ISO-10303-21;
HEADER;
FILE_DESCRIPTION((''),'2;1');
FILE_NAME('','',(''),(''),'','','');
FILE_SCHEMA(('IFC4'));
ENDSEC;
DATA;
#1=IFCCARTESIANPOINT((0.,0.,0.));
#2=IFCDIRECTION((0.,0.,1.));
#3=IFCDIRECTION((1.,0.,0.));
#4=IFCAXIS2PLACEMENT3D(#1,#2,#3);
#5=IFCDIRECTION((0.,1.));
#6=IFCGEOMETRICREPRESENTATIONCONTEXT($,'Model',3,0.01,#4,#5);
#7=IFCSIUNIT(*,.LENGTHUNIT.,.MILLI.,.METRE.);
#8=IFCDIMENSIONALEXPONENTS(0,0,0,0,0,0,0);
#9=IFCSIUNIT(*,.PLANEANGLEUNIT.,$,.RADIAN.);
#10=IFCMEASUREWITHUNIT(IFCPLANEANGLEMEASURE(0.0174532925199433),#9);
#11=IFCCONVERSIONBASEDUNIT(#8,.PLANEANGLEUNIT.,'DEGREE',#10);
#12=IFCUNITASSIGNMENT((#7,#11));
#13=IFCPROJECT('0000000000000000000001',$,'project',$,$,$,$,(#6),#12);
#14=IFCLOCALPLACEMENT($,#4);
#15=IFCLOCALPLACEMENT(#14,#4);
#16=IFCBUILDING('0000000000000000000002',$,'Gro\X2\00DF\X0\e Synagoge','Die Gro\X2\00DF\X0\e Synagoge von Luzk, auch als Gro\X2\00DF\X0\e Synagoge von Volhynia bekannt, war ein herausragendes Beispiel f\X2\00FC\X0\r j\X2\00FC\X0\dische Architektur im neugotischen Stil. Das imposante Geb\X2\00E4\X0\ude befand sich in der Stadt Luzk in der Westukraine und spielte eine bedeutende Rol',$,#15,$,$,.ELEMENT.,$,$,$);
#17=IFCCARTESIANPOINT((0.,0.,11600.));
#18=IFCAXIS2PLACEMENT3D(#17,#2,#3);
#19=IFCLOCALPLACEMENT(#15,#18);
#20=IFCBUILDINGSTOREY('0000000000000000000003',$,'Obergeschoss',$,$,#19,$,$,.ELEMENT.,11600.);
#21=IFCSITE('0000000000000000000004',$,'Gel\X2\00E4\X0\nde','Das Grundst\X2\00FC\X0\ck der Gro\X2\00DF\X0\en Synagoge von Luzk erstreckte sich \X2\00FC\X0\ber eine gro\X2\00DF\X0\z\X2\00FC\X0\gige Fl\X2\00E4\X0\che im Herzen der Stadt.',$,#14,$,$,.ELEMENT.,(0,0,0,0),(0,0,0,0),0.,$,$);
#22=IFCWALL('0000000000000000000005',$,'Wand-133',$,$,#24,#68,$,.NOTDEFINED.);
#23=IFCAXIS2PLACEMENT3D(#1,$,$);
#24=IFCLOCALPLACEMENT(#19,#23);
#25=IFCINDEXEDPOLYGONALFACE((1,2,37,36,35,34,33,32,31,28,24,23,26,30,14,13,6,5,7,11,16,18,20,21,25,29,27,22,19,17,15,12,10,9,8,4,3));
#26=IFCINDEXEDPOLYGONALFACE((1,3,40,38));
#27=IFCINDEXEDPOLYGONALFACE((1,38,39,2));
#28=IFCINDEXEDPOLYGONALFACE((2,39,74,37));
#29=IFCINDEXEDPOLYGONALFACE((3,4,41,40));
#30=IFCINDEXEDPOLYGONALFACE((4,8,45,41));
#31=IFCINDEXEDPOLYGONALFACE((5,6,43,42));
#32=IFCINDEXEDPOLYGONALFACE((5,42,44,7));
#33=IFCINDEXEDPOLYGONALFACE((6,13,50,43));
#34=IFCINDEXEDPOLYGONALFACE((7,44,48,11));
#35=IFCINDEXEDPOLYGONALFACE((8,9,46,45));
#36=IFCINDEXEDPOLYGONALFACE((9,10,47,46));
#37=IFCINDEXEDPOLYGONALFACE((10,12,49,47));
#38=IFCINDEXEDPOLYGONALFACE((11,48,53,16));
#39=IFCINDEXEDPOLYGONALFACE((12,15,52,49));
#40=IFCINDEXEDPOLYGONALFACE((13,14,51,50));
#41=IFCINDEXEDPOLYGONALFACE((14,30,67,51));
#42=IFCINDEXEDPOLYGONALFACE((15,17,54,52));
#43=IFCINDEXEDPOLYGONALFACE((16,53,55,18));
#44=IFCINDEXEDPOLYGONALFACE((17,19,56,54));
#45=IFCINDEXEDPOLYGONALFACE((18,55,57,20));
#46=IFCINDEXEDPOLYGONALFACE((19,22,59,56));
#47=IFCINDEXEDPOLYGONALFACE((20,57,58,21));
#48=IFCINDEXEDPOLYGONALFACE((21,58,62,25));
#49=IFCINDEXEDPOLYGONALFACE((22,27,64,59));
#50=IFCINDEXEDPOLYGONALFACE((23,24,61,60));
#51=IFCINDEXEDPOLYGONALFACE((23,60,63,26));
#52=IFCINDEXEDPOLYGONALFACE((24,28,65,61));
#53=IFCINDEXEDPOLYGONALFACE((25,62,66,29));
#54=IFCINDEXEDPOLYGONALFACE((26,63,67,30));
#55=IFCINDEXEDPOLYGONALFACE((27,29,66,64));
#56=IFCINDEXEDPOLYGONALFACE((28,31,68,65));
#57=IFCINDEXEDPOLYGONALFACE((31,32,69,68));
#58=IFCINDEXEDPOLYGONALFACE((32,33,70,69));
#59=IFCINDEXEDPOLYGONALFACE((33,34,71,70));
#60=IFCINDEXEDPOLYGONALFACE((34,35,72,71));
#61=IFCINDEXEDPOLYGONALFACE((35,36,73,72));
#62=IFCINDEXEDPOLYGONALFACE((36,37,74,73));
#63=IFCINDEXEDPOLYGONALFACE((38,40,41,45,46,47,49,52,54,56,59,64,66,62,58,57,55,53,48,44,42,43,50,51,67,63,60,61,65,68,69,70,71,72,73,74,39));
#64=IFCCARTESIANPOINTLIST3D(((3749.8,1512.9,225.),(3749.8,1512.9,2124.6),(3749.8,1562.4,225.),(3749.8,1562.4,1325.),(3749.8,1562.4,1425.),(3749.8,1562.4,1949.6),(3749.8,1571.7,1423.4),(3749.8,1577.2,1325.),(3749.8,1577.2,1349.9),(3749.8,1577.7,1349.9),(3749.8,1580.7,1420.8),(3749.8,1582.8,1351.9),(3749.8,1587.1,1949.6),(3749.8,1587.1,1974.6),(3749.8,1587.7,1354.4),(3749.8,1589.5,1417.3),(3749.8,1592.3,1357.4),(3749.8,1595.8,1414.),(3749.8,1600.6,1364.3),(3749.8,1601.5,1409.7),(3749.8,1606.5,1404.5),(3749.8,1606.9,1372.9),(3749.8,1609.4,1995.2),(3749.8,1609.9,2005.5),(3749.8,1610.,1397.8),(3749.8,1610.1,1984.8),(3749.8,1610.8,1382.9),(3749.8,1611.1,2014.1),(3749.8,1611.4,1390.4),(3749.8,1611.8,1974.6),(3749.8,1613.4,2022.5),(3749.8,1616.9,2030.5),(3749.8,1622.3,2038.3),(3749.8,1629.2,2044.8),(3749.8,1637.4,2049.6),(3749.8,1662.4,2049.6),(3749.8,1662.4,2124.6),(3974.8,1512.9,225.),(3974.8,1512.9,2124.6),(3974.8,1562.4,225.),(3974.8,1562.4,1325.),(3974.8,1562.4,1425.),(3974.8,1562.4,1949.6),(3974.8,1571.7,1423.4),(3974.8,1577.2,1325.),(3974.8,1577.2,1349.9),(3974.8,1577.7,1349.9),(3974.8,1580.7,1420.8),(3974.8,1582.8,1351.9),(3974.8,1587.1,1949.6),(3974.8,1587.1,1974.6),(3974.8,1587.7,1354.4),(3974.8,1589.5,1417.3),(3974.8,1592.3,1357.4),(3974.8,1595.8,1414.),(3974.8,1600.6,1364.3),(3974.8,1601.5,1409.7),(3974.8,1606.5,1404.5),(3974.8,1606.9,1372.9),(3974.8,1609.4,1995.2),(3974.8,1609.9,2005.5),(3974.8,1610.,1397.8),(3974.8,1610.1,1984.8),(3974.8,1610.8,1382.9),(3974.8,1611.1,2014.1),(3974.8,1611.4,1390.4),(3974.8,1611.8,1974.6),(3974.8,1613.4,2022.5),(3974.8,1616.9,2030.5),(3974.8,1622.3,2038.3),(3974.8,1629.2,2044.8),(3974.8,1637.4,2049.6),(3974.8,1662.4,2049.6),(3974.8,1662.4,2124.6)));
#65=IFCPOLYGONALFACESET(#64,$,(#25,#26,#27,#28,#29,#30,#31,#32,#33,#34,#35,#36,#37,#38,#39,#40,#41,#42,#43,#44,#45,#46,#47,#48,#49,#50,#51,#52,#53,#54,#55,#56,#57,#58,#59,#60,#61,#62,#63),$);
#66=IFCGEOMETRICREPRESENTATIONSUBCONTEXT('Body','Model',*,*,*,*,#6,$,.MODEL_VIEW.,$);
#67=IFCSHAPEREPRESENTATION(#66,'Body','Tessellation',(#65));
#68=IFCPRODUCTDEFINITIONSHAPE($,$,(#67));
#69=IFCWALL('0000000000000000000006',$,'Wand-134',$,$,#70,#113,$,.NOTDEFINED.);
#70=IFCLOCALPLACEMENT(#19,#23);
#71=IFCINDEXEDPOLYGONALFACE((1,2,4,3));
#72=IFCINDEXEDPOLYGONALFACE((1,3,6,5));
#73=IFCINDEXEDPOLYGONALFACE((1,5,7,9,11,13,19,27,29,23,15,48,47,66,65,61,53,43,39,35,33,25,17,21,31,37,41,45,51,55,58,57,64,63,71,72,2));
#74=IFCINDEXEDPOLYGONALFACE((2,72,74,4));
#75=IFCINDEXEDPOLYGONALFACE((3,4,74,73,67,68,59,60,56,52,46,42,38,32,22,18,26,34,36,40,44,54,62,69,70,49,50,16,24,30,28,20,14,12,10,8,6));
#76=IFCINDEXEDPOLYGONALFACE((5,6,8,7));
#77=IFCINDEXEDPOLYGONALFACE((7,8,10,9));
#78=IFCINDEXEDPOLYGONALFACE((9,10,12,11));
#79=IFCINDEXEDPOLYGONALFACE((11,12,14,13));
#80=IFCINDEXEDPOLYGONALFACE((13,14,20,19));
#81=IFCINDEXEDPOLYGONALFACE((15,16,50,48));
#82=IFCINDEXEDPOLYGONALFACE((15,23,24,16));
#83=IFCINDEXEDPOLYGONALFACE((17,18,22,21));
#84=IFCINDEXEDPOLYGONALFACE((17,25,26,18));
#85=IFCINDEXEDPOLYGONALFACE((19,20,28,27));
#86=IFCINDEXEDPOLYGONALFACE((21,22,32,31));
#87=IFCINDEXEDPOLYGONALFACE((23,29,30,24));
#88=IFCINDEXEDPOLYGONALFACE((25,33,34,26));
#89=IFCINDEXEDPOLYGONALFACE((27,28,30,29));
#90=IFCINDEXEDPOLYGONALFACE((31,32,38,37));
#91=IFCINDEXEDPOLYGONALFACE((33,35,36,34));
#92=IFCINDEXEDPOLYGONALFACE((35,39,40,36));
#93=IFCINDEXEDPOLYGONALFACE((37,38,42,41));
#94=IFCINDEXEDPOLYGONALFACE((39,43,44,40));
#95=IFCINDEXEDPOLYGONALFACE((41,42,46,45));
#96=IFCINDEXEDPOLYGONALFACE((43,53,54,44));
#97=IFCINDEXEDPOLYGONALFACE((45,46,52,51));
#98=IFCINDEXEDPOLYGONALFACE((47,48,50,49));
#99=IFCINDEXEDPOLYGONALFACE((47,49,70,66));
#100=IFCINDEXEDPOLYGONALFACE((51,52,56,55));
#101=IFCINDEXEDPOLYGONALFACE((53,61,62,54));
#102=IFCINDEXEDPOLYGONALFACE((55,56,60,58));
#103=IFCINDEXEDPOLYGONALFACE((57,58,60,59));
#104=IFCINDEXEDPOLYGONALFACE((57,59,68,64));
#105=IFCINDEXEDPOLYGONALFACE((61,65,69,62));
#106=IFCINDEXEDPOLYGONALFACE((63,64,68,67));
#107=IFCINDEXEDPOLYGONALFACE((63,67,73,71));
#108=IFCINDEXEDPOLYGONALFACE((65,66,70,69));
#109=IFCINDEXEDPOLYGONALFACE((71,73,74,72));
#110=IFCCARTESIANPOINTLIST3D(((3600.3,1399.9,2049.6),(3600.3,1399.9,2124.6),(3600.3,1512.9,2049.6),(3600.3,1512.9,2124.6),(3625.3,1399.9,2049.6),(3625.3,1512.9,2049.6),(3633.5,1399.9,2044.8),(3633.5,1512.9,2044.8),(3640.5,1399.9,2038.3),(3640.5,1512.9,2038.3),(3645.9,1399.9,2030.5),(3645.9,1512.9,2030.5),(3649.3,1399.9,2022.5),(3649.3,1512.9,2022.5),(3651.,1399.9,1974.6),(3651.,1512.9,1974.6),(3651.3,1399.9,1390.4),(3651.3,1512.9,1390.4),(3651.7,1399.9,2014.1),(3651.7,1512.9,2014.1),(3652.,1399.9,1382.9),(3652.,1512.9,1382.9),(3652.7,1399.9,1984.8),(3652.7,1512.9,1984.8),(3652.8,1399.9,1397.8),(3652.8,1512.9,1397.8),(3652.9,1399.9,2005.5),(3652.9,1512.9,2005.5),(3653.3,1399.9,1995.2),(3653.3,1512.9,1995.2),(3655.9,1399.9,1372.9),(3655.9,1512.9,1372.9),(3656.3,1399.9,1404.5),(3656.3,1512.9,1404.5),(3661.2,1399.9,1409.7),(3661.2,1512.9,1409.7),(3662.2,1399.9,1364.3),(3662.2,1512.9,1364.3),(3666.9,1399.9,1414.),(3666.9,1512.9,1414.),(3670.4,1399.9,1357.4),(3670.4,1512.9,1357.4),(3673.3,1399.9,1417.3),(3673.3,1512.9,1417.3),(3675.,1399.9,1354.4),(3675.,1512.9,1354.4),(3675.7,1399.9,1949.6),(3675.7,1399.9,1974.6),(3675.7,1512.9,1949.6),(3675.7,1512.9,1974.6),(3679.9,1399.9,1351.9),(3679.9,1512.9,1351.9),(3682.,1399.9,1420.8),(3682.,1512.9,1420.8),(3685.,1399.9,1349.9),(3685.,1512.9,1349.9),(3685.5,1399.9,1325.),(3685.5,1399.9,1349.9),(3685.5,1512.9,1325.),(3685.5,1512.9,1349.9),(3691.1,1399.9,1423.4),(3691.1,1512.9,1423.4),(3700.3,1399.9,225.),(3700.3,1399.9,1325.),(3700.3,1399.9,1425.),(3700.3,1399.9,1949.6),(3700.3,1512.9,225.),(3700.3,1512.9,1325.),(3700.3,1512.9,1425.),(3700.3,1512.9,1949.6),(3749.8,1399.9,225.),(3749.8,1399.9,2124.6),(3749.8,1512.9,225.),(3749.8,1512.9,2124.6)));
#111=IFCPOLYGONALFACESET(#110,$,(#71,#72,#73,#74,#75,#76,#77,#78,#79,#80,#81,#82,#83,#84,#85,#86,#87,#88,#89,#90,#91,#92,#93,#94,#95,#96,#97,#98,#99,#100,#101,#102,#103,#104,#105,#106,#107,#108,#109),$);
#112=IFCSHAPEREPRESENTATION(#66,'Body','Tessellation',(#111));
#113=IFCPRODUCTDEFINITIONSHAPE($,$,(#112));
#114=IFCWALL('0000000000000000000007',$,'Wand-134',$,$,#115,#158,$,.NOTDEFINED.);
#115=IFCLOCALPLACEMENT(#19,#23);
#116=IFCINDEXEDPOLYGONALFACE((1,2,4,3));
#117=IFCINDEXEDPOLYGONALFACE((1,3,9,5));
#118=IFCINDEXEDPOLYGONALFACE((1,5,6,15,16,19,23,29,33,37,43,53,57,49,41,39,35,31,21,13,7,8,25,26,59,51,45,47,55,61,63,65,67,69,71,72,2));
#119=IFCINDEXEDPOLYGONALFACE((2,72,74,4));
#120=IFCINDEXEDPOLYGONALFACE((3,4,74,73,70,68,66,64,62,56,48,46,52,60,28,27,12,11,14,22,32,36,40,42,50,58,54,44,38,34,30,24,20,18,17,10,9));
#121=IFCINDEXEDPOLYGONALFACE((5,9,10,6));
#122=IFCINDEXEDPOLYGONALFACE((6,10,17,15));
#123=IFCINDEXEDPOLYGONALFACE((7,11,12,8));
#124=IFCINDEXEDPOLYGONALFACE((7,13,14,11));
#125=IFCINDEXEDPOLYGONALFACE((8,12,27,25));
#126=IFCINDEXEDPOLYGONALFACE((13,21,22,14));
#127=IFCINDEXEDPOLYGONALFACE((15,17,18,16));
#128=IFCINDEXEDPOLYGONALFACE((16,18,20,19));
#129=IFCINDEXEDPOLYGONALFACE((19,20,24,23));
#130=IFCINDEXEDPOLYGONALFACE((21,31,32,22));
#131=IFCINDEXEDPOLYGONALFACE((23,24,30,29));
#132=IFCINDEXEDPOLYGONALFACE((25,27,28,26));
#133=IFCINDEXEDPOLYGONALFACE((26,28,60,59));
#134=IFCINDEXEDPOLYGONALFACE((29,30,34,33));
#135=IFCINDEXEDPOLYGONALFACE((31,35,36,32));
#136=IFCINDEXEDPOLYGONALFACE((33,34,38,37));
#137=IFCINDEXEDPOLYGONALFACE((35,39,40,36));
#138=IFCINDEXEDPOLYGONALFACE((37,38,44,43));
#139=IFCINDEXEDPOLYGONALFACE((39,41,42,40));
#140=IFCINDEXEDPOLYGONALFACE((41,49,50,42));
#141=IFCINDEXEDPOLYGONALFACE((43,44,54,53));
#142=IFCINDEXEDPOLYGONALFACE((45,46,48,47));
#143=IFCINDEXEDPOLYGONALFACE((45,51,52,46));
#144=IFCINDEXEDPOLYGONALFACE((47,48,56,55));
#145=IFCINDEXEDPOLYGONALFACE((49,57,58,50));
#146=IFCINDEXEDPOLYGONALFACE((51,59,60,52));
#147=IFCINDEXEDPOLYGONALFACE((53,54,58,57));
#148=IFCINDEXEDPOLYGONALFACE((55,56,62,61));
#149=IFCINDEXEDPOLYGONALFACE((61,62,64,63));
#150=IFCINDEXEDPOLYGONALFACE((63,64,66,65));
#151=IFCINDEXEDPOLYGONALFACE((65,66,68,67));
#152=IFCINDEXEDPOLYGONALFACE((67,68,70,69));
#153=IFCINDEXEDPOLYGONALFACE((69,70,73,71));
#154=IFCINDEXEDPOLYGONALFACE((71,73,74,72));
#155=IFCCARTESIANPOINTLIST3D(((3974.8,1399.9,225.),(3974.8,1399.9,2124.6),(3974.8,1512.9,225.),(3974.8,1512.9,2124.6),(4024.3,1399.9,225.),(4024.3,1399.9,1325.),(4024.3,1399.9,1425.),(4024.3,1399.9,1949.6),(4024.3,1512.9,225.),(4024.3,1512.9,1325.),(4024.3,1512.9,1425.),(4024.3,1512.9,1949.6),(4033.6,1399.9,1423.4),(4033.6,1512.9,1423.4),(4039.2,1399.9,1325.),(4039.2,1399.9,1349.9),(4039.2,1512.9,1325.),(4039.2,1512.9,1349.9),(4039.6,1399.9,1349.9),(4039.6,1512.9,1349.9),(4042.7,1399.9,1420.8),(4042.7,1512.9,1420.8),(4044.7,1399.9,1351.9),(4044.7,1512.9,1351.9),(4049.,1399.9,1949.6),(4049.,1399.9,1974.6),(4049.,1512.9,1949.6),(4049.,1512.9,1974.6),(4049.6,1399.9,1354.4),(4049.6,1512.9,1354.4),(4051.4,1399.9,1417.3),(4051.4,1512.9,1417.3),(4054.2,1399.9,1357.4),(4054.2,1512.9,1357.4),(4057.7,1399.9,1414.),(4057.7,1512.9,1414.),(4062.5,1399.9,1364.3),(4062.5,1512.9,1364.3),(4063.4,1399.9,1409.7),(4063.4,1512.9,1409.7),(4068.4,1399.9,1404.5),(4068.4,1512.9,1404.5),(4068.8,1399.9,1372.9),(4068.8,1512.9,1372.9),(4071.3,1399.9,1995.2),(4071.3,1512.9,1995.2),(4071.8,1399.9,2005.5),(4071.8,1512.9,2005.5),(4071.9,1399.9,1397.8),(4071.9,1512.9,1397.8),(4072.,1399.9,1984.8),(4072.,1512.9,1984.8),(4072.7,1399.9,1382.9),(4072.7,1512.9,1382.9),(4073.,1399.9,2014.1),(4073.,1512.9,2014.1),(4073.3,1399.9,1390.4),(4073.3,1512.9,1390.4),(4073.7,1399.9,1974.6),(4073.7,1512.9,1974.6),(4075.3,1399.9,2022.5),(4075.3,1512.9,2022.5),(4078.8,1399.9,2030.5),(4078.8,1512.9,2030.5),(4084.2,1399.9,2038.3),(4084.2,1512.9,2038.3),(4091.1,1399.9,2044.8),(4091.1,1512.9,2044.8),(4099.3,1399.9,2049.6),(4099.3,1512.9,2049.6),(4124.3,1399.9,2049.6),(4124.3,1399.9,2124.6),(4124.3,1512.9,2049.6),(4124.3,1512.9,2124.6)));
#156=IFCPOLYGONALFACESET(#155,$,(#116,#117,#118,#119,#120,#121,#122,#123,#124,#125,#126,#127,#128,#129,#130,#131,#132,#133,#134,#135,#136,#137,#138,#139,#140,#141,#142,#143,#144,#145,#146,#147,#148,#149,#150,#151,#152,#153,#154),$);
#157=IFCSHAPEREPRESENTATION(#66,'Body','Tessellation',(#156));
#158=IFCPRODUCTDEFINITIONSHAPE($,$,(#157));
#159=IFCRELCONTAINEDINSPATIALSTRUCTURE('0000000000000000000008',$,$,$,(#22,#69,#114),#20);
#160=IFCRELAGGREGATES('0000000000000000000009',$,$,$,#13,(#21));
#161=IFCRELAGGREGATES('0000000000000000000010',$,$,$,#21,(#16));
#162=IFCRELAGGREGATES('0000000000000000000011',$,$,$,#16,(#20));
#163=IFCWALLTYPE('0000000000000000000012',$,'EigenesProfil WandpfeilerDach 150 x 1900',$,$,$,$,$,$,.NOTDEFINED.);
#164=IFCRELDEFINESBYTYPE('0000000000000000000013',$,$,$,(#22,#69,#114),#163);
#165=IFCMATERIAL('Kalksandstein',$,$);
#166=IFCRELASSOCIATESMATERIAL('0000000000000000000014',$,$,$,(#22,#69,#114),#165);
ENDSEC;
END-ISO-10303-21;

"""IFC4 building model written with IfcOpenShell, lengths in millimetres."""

from ifc_helpers import new_model, entity, si_unit, converted_unit, direction, frame, origin_with_axes, place, context, subcontext, project, spatial, line, arc, indexed_curve, outline, extrude, material, material_profile, profile_set, type_object, element, save


model = new_model("IFC4")

# Units and contexts
model_context = context("Model", 3, precision=0.01, world=origin_with_axes(), true_north=direction((0.0, 1.0)))
body_context = subcontext(model_context, "Body", "Model", "MODEL_VIEW")
ifc_project = project(units=[si_unit("LENGTHUNIT", "METRE", prefix="MILLI"), converted_unit("PLANEANGLEUNIT", "DEGREE", entity("IfcPlaneAngleMeasure", 0.0174532925199433), si_unit("PLANEANGLEUNIT", "RADIAN"), dimensions=[0, 0, 0, 0, 0, 0, 0])], contexts=[model_context])

# Site, building, storey
site_placement = place(None, origin_with_axes())
site = spatial("IfcSite", under=ifc_project, at=site_placement, Name="Gelände", Description="Das Grundstück der Großen Synagoge von Luzk erstreckte sich über eine großzügige Fläche im Herzen der Stadt.", CompositionType="ELEMENT", RefLatitude=(0, 0, 0, 0), RefLongitude=(0, 0, 0, 0), RefElevation=0.0)
building_placement = place(site_placement, origin_with_axes())
building = spatial("IfcBuilding", under=site, at=building_placement, Name="Große Synagoge", Description="Die Große Synagoge von Luzk, auch als Große Synagoge von Volhynia bekannt, war ein herausragendes Beispiel für jüdische Architektur im neugotischen Stil. Das imposante Gebäude befand sich in der Stadt Luzk in der Westukraine und spielte eine bedeutende Rol", CompositionType="ELEMENT")
storey_placement = place(building_placement, frame((0.0, 0.0, 11600.0), z_axis=(0.0, 0.0, 1.0), x_axis=(1.0, 0.0, 0.0)))
storey = spatial("IfcBuildingStorey", under=building, at=storey_placement, Name="Obergeschoss", CompositionType="ELEMENT", Elevation=11600.0)

# Walls
ifc_material_1 = material(Name="Kalksandstein")
ifc_material_profile = material_profile(ifc_material_1, outline(indexed_curve([(74.2, 1749.6), (98.9, 1749.6), (96.7, 1765.0), (97.0, 1780.5), (99.2, 1793.4), (103.9, 1805.5), (112.6, 1816.7), (124.5, 1824.6), (149.5, 1824.6), (149.5, 1899.6), (0.0, 1899.6), (0.0, 0.0), (49.5, 0.0), (49.5, 1100.0), (64.3, 1100.0), (64.3, 1124.9), (64.8, 1124.9), (72.4, 1128.1), (79.4, 1132.4), (91.1, 1143.4), (97.9, 1157.9), (98.0, 1169.2), (93.5, 1179.5), (85.8, 1187.0), (76.6, 1192.3), (63.3, 1197.2), (49.5, 1200.0), (49.5, 1724.6), (74.2, 1724.6)], segments=[line(1, 2), arc(2, 3, 4), arc(4, 5, 6), arc(6, 7, 8), line(8, 9, 10, 11, 12, 13, 14, 15, 16, 17), arc(17, 18, 19), arc(19, 20, 21), arc(21, 22, 23), arc(23, 24, 25), arc(25, 26, 27), line(27, 28, 29, 1)])), Name="Kalksandstein")
ifc_profile_set = profile_set([ifc_material_profile], Name="EigenesProfil WandpfeilerDach")
wall_type_1 = type_object("IfcWallType", Name="EigenesProfil WandpfeilerDach 150 x 1900", PredefinedType="NOTDEFINED")
wall_1_placement = place(storey_placement, frame((3749.8, 1512.9, 225.0), z_axis=(0.0, 0.0, 1.0), x_axis=(1.0, 0.0, 0.0)))
element("IfcWall", 1, at=wall_1_placement, inside=storey, type_object=wall_type_1, material=ifc_profile_set, Name="Wand-133", PredefinedType="NOTDEFINED", context=body_context, shape_type="SweptSolid", body=[
    extrude(outline(indexed_curve([(74.2, 1749.6), (98.9, 1749.6), (96.7, 1765.0), (97.0, 1780.5), (99.2, 1793.4), (103.9, 1805.5), (112.6, 1816.7), (124.5, 1824.6), (149.5, 1824.6), (149.5, 1899.6), (0.0, 1899.6), (0.0, 0.0), (49.5, 0.0), (49.5, 1100.0), (64.3, 1100.0), (64.3, 1124.9), (64.8, 1124.9), (72.4, 1128.1), (79.4, 1132.4), (91.1, 1143.4), (97.9, 1157.9), (98.0, 1169.2), (93.5, 1179.5), (85.8, 1187.0), (76.6, 1192.3), (63.3, 1197.2), (49.5, 1200.0), (49.5, 1724.6), (74.2, 1724.6)], segments=[line(1, 2), arc(2, 3, 4), arc(4, 5, 6), arc(6, 7, 8), line(8, 9, 10, 11, 12, 13, 14, 15, 16, 17), arc(17, 18, 19), arc(19, 20, 21), arc(21, 22, 23), arc(23, 24, 25), arc(25, 26, 27), line(27, 28, 29, 1)])), frame((0.0, 0.0, 0.0), z_axis=(1.0, 0.0, 0.0), x_axis=(0.0, 1.0, 0.0)), (0.0, 0.0, 1.0), 225.0),
])
wall_2_placement = place(storey_placement, frame((3749.8, 1512.9, 225.0), z_axis=(0.0, 0.0, 1.0), x_axis=(0.0, -1.0, 0.0)))
element("IfcWall", 2, at=wall_2_placement, inside=storey, type_object=wall_type_1, material=ifc_profile_set, Name="Wand-134", PredefinedType="NOTDEFINED", context=body_context, shape_type="SweptSolid", body=[
    extrude(outline(indexed_curve([(74.2, 1749.6), (98.9, 1749.6), (96.7, 1765.0), (97.0, 1780.5), (99.2, 1793.4), (103.9, 1805.5), (112.6, 1816.7), (124.5, 1824.6), (149.5, 1824.6), (149.5, 1899.6), (0.0, 1899.6), (0.0, 0.0), (49.5, 0.0), (49.5, 1100.0), (64.3, 1100.0), (64.3, 1124.9), (64.8, 1124.9), (72.4, 1128.1), (79.4, 1132.4), (91.1, 1143.4), (97.9, 1157.9), (98.0, 1169.2), (93.5, 1179.5), (85.8, 1187.0), (76.6, 1192.3), (63.3, 1197.2), (49.5, 1200.0), (49.5, 1724.6), (74.2, 1724.6)], segments=[line(1, 2), arc(2, 3, 4), arc(4, 5, 6), arc(6, 7, 8), line(8, 9, 10, 11, 12, 13, 14, 15, 16, 17), arc(17, 18, 19), arc(19, 20, 21), arc(21, 22, 23), arc(23, 24, 25), arc(25, 26, 27), line(27, 28, 29, 1)])), frame((0.0, 0.0, 0.0), z_axis=(-1.0, 0.0, 0.0), x_axis=(0.0, -1.0, 0.0)), (0.0, 0.0, -1.0), 113.0),
])
for number, where, z_axis, x_axis, name in (
    (3, (3974.8, 1512.9, 225.0), (0.0, 0.0, 1.0), (0.0, -1.0, 0.0), "Wand-134"),
):
    element("IfcWall", number, at=place(storey_placement, frame(where, z_axis=z_axis, x_axis=x_axis)), inside=storey, type_object=wall_type_1, material=ifc_profile_set, Name=name, PredefinedType="NOTDEFINED", context=body_context, shape_type="SweptSolid", body=[
        extrude(outline(indexed_curve([(74.2, 1749.6), (98.9, 1749.6), (96.7, 1765.0), (97.0, 1780.5), (99.2, 1793.4), (103.9, 1805.5), (112.6, 1816.7), (124.5, 1824.6), (149.5, 1824.6), (149.5, 1899.6), (0.0, 1899.6), (0.0, 0.0), (49.5, 0.0), (49.5, 1100.0), (64.3, 1100.0), (64.3, 1124.9), (64.8, 1124.9), (72.4, 1128.1), (79.4, 1132.4), (91.1, 1143.4), (97.9, 1157.9), (98.0, 1169.2), (93.5, 1179.5), (85.8, 1187.0), (76.6, 1192.3), (63.3, 1197.2), (49.5, 1200.0), (49.5, 1724.6), (74.2, 1724.6)], segments=[line(1, 2), arc(2, 3, 4), arc(4, 5, 6), arc(6, 7, 8), line(8, 9, 10, 11, 12, 13, 14, 15, 16, 17), arc(17, 18, 19), arc(19, 20, 21), arc(21, 22, 23), arc(23, 24, 25), arc(25, 26, 27), line(27, 28, 29, 1)])), frame((0.0, 0.0, 0.0), z_axis=(1.0, 0.0, 0.0), x_axis=(0.0, 1.0, 0.0)), (0.0, 0.0, 1.0), 113.0),
    ])

save(model, "model.ifc")
